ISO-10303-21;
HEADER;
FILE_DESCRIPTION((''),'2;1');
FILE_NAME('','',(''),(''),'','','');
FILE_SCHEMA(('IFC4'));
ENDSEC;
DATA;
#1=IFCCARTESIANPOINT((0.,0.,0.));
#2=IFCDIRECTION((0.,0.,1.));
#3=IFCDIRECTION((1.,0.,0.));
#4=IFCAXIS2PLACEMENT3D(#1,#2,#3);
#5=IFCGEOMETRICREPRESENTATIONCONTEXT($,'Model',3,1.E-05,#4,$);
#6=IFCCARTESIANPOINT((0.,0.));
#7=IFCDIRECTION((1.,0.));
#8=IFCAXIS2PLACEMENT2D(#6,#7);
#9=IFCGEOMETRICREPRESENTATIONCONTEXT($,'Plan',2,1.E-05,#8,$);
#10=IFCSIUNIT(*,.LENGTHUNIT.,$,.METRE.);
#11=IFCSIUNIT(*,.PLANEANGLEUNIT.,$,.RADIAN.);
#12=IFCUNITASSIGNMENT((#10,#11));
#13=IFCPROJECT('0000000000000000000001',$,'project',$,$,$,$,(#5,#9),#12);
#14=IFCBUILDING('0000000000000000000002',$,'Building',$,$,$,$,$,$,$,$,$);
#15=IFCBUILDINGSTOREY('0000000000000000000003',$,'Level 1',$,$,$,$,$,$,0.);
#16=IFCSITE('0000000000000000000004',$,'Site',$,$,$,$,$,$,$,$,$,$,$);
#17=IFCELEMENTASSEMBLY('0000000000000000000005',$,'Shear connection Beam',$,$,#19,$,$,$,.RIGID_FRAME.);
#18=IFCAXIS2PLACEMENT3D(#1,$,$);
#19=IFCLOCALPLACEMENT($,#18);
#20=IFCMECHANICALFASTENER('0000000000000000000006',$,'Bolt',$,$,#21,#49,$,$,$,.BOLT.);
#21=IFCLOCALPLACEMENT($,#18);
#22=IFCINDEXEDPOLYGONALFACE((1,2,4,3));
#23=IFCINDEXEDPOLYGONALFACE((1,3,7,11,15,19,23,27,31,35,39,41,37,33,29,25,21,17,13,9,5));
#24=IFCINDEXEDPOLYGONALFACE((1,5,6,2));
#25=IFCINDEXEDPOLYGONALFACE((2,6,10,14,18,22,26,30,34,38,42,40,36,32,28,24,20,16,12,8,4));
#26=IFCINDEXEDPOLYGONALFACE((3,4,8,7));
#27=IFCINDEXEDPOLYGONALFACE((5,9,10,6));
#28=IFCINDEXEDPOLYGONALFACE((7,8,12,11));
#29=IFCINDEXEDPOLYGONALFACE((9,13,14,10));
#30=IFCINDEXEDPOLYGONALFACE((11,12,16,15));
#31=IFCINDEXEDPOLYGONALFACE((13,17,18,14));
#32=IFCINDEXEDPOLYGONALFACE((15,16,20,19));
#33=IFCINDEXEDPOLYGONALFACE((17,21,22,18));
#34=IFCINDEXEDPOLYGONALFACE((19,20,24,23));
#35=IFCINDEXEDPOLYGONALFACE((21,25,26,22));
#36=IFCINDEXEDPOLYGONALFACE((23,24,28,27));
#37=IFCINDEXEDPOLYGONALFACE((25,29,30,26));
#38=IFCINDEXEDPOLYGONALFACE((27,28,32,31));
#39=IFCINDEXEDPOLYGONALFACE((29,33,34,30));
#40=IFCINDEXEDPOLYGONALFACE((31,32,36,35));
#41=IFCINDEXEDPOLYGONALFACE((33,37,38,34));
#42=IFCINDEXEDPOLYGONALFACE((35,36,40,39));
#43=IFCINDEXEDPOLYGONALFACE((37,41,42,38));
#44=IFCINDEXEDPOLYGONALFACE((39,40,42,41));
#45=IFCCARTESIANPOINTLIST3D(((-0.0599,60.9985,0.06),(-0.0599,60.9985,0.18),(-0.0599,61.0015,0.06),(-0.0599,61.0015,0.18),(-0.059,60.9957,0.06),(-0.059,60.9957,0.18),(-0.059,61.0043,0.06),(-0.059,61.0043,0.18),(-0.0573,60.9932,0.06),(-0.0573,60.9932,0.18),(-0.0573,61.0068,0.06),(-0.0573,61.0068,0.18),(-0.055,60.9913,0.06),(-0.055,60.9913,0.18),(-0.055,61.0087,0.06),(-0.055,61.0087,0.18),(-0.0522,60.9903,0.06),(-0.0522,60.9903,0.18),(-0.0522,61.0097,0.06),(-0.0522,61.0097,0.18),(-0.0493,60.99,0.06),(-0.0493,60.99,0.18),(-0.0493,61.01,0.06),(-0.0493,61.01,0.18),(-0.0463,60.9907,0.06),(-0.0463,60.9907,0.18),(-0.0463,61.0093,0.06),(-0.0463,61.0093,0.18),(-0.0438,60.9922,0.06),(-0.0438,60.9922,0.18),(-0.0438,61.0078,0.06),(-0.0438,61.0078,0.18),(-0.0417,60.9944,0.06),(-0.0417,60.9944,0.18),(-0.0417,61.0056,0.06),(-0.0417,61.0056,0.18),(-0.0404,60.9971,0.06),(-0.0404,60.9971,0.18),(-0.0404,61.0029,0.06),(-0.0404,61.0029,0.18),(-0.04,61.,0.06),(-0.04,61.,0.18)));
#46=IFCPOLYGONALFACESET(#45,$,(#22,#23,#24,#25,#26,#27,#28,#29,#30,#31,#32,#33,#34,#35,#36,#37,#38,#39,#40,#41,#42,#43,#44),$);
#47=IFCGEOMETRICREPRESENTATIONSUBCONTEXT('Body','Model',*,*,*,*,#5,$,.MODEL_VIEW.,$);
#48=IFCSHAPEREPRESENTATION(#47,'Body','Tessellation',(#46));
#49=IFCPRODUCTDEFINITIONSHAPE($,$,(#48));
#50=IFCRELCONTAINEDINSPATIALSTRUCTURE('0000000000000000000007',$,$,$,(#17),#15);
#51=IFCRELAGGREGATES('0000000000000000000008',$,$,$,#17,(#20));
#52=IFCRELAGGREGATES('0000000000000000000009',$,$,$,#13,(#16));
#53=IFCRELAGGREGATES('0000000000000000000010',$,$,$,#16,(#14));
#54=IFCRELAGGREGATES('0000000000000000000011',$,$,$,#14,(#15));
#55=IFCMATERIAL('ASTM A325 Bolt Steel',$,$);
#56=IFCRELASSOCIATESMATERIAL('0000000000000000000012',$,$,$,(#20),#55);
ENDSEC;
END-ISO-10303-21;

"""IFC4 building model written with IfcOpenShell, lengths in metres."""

from ifc_helpers import new_model, si_unit, frame, origin_with_axes, origin_2d, origin_2d_with_axis, place, context, subcontext, project, spatial, circle, extrude, material, element, aggregate, save


model = new_model("IFC4")

# Units and contexts
model_context = context("Model", 3, precision=1e-05, world=origin_with_axes())
plan_context = context("Plan", 2, precision=1e-05, world=origin_2d_with_axis())
body_context = subcontext(model_context, "Body", "Model", "MODEL_VIEW")
ifc_project = project(units=[si_unit("LENGTHUNIT", "METRE"), si_unit("PLANEANGLEUNIT", "RADIAN")], contexts=[model_context, plan_context])

# Site, building, storey
site = spatial("IfcSite", under=ifc_project, Name="Site")
building = spatial("IfcBuilding", under=site, Name="Building")
storey = spatial("IfcBuildingStorey", under=building, Name="Level 1", Elevation=0.0)

# Element assembly
assembly_1 = element("IfcElementAssembly", 1, inside=storey, Name="Shear connection Beam", PredefinedType="RIGID_FRAME")

# Shared definitions
ifc_material_1 = material(Name="ASTM A325 Bolt Steel")

# Mechanical fastener
mechanical_fastener_1_placement = place(None, frame((-0.05, 61.0, 0.06), z_axis=(0.0, 0.0, 1.0), x_axis=(1.0, 0.0, 0.0)))
mechanical_fastener_1 = element("IfcMechanicalFastener", 2, at=mechanical_fastener_1_placement, material=ifc_material_1, Name="Bolt", PredefinedType="BOLT", context=body_context, shape_type="SweptSolid", body=[
    extrude(circle(Radius=0.01, at=origin_2d()), origin_with_axes(), (0.0, 0.0, 1.0), 0.12),
])
aggregate(assembly_1, [mechanical_fastener_1])

save(model, "model.ifc")
